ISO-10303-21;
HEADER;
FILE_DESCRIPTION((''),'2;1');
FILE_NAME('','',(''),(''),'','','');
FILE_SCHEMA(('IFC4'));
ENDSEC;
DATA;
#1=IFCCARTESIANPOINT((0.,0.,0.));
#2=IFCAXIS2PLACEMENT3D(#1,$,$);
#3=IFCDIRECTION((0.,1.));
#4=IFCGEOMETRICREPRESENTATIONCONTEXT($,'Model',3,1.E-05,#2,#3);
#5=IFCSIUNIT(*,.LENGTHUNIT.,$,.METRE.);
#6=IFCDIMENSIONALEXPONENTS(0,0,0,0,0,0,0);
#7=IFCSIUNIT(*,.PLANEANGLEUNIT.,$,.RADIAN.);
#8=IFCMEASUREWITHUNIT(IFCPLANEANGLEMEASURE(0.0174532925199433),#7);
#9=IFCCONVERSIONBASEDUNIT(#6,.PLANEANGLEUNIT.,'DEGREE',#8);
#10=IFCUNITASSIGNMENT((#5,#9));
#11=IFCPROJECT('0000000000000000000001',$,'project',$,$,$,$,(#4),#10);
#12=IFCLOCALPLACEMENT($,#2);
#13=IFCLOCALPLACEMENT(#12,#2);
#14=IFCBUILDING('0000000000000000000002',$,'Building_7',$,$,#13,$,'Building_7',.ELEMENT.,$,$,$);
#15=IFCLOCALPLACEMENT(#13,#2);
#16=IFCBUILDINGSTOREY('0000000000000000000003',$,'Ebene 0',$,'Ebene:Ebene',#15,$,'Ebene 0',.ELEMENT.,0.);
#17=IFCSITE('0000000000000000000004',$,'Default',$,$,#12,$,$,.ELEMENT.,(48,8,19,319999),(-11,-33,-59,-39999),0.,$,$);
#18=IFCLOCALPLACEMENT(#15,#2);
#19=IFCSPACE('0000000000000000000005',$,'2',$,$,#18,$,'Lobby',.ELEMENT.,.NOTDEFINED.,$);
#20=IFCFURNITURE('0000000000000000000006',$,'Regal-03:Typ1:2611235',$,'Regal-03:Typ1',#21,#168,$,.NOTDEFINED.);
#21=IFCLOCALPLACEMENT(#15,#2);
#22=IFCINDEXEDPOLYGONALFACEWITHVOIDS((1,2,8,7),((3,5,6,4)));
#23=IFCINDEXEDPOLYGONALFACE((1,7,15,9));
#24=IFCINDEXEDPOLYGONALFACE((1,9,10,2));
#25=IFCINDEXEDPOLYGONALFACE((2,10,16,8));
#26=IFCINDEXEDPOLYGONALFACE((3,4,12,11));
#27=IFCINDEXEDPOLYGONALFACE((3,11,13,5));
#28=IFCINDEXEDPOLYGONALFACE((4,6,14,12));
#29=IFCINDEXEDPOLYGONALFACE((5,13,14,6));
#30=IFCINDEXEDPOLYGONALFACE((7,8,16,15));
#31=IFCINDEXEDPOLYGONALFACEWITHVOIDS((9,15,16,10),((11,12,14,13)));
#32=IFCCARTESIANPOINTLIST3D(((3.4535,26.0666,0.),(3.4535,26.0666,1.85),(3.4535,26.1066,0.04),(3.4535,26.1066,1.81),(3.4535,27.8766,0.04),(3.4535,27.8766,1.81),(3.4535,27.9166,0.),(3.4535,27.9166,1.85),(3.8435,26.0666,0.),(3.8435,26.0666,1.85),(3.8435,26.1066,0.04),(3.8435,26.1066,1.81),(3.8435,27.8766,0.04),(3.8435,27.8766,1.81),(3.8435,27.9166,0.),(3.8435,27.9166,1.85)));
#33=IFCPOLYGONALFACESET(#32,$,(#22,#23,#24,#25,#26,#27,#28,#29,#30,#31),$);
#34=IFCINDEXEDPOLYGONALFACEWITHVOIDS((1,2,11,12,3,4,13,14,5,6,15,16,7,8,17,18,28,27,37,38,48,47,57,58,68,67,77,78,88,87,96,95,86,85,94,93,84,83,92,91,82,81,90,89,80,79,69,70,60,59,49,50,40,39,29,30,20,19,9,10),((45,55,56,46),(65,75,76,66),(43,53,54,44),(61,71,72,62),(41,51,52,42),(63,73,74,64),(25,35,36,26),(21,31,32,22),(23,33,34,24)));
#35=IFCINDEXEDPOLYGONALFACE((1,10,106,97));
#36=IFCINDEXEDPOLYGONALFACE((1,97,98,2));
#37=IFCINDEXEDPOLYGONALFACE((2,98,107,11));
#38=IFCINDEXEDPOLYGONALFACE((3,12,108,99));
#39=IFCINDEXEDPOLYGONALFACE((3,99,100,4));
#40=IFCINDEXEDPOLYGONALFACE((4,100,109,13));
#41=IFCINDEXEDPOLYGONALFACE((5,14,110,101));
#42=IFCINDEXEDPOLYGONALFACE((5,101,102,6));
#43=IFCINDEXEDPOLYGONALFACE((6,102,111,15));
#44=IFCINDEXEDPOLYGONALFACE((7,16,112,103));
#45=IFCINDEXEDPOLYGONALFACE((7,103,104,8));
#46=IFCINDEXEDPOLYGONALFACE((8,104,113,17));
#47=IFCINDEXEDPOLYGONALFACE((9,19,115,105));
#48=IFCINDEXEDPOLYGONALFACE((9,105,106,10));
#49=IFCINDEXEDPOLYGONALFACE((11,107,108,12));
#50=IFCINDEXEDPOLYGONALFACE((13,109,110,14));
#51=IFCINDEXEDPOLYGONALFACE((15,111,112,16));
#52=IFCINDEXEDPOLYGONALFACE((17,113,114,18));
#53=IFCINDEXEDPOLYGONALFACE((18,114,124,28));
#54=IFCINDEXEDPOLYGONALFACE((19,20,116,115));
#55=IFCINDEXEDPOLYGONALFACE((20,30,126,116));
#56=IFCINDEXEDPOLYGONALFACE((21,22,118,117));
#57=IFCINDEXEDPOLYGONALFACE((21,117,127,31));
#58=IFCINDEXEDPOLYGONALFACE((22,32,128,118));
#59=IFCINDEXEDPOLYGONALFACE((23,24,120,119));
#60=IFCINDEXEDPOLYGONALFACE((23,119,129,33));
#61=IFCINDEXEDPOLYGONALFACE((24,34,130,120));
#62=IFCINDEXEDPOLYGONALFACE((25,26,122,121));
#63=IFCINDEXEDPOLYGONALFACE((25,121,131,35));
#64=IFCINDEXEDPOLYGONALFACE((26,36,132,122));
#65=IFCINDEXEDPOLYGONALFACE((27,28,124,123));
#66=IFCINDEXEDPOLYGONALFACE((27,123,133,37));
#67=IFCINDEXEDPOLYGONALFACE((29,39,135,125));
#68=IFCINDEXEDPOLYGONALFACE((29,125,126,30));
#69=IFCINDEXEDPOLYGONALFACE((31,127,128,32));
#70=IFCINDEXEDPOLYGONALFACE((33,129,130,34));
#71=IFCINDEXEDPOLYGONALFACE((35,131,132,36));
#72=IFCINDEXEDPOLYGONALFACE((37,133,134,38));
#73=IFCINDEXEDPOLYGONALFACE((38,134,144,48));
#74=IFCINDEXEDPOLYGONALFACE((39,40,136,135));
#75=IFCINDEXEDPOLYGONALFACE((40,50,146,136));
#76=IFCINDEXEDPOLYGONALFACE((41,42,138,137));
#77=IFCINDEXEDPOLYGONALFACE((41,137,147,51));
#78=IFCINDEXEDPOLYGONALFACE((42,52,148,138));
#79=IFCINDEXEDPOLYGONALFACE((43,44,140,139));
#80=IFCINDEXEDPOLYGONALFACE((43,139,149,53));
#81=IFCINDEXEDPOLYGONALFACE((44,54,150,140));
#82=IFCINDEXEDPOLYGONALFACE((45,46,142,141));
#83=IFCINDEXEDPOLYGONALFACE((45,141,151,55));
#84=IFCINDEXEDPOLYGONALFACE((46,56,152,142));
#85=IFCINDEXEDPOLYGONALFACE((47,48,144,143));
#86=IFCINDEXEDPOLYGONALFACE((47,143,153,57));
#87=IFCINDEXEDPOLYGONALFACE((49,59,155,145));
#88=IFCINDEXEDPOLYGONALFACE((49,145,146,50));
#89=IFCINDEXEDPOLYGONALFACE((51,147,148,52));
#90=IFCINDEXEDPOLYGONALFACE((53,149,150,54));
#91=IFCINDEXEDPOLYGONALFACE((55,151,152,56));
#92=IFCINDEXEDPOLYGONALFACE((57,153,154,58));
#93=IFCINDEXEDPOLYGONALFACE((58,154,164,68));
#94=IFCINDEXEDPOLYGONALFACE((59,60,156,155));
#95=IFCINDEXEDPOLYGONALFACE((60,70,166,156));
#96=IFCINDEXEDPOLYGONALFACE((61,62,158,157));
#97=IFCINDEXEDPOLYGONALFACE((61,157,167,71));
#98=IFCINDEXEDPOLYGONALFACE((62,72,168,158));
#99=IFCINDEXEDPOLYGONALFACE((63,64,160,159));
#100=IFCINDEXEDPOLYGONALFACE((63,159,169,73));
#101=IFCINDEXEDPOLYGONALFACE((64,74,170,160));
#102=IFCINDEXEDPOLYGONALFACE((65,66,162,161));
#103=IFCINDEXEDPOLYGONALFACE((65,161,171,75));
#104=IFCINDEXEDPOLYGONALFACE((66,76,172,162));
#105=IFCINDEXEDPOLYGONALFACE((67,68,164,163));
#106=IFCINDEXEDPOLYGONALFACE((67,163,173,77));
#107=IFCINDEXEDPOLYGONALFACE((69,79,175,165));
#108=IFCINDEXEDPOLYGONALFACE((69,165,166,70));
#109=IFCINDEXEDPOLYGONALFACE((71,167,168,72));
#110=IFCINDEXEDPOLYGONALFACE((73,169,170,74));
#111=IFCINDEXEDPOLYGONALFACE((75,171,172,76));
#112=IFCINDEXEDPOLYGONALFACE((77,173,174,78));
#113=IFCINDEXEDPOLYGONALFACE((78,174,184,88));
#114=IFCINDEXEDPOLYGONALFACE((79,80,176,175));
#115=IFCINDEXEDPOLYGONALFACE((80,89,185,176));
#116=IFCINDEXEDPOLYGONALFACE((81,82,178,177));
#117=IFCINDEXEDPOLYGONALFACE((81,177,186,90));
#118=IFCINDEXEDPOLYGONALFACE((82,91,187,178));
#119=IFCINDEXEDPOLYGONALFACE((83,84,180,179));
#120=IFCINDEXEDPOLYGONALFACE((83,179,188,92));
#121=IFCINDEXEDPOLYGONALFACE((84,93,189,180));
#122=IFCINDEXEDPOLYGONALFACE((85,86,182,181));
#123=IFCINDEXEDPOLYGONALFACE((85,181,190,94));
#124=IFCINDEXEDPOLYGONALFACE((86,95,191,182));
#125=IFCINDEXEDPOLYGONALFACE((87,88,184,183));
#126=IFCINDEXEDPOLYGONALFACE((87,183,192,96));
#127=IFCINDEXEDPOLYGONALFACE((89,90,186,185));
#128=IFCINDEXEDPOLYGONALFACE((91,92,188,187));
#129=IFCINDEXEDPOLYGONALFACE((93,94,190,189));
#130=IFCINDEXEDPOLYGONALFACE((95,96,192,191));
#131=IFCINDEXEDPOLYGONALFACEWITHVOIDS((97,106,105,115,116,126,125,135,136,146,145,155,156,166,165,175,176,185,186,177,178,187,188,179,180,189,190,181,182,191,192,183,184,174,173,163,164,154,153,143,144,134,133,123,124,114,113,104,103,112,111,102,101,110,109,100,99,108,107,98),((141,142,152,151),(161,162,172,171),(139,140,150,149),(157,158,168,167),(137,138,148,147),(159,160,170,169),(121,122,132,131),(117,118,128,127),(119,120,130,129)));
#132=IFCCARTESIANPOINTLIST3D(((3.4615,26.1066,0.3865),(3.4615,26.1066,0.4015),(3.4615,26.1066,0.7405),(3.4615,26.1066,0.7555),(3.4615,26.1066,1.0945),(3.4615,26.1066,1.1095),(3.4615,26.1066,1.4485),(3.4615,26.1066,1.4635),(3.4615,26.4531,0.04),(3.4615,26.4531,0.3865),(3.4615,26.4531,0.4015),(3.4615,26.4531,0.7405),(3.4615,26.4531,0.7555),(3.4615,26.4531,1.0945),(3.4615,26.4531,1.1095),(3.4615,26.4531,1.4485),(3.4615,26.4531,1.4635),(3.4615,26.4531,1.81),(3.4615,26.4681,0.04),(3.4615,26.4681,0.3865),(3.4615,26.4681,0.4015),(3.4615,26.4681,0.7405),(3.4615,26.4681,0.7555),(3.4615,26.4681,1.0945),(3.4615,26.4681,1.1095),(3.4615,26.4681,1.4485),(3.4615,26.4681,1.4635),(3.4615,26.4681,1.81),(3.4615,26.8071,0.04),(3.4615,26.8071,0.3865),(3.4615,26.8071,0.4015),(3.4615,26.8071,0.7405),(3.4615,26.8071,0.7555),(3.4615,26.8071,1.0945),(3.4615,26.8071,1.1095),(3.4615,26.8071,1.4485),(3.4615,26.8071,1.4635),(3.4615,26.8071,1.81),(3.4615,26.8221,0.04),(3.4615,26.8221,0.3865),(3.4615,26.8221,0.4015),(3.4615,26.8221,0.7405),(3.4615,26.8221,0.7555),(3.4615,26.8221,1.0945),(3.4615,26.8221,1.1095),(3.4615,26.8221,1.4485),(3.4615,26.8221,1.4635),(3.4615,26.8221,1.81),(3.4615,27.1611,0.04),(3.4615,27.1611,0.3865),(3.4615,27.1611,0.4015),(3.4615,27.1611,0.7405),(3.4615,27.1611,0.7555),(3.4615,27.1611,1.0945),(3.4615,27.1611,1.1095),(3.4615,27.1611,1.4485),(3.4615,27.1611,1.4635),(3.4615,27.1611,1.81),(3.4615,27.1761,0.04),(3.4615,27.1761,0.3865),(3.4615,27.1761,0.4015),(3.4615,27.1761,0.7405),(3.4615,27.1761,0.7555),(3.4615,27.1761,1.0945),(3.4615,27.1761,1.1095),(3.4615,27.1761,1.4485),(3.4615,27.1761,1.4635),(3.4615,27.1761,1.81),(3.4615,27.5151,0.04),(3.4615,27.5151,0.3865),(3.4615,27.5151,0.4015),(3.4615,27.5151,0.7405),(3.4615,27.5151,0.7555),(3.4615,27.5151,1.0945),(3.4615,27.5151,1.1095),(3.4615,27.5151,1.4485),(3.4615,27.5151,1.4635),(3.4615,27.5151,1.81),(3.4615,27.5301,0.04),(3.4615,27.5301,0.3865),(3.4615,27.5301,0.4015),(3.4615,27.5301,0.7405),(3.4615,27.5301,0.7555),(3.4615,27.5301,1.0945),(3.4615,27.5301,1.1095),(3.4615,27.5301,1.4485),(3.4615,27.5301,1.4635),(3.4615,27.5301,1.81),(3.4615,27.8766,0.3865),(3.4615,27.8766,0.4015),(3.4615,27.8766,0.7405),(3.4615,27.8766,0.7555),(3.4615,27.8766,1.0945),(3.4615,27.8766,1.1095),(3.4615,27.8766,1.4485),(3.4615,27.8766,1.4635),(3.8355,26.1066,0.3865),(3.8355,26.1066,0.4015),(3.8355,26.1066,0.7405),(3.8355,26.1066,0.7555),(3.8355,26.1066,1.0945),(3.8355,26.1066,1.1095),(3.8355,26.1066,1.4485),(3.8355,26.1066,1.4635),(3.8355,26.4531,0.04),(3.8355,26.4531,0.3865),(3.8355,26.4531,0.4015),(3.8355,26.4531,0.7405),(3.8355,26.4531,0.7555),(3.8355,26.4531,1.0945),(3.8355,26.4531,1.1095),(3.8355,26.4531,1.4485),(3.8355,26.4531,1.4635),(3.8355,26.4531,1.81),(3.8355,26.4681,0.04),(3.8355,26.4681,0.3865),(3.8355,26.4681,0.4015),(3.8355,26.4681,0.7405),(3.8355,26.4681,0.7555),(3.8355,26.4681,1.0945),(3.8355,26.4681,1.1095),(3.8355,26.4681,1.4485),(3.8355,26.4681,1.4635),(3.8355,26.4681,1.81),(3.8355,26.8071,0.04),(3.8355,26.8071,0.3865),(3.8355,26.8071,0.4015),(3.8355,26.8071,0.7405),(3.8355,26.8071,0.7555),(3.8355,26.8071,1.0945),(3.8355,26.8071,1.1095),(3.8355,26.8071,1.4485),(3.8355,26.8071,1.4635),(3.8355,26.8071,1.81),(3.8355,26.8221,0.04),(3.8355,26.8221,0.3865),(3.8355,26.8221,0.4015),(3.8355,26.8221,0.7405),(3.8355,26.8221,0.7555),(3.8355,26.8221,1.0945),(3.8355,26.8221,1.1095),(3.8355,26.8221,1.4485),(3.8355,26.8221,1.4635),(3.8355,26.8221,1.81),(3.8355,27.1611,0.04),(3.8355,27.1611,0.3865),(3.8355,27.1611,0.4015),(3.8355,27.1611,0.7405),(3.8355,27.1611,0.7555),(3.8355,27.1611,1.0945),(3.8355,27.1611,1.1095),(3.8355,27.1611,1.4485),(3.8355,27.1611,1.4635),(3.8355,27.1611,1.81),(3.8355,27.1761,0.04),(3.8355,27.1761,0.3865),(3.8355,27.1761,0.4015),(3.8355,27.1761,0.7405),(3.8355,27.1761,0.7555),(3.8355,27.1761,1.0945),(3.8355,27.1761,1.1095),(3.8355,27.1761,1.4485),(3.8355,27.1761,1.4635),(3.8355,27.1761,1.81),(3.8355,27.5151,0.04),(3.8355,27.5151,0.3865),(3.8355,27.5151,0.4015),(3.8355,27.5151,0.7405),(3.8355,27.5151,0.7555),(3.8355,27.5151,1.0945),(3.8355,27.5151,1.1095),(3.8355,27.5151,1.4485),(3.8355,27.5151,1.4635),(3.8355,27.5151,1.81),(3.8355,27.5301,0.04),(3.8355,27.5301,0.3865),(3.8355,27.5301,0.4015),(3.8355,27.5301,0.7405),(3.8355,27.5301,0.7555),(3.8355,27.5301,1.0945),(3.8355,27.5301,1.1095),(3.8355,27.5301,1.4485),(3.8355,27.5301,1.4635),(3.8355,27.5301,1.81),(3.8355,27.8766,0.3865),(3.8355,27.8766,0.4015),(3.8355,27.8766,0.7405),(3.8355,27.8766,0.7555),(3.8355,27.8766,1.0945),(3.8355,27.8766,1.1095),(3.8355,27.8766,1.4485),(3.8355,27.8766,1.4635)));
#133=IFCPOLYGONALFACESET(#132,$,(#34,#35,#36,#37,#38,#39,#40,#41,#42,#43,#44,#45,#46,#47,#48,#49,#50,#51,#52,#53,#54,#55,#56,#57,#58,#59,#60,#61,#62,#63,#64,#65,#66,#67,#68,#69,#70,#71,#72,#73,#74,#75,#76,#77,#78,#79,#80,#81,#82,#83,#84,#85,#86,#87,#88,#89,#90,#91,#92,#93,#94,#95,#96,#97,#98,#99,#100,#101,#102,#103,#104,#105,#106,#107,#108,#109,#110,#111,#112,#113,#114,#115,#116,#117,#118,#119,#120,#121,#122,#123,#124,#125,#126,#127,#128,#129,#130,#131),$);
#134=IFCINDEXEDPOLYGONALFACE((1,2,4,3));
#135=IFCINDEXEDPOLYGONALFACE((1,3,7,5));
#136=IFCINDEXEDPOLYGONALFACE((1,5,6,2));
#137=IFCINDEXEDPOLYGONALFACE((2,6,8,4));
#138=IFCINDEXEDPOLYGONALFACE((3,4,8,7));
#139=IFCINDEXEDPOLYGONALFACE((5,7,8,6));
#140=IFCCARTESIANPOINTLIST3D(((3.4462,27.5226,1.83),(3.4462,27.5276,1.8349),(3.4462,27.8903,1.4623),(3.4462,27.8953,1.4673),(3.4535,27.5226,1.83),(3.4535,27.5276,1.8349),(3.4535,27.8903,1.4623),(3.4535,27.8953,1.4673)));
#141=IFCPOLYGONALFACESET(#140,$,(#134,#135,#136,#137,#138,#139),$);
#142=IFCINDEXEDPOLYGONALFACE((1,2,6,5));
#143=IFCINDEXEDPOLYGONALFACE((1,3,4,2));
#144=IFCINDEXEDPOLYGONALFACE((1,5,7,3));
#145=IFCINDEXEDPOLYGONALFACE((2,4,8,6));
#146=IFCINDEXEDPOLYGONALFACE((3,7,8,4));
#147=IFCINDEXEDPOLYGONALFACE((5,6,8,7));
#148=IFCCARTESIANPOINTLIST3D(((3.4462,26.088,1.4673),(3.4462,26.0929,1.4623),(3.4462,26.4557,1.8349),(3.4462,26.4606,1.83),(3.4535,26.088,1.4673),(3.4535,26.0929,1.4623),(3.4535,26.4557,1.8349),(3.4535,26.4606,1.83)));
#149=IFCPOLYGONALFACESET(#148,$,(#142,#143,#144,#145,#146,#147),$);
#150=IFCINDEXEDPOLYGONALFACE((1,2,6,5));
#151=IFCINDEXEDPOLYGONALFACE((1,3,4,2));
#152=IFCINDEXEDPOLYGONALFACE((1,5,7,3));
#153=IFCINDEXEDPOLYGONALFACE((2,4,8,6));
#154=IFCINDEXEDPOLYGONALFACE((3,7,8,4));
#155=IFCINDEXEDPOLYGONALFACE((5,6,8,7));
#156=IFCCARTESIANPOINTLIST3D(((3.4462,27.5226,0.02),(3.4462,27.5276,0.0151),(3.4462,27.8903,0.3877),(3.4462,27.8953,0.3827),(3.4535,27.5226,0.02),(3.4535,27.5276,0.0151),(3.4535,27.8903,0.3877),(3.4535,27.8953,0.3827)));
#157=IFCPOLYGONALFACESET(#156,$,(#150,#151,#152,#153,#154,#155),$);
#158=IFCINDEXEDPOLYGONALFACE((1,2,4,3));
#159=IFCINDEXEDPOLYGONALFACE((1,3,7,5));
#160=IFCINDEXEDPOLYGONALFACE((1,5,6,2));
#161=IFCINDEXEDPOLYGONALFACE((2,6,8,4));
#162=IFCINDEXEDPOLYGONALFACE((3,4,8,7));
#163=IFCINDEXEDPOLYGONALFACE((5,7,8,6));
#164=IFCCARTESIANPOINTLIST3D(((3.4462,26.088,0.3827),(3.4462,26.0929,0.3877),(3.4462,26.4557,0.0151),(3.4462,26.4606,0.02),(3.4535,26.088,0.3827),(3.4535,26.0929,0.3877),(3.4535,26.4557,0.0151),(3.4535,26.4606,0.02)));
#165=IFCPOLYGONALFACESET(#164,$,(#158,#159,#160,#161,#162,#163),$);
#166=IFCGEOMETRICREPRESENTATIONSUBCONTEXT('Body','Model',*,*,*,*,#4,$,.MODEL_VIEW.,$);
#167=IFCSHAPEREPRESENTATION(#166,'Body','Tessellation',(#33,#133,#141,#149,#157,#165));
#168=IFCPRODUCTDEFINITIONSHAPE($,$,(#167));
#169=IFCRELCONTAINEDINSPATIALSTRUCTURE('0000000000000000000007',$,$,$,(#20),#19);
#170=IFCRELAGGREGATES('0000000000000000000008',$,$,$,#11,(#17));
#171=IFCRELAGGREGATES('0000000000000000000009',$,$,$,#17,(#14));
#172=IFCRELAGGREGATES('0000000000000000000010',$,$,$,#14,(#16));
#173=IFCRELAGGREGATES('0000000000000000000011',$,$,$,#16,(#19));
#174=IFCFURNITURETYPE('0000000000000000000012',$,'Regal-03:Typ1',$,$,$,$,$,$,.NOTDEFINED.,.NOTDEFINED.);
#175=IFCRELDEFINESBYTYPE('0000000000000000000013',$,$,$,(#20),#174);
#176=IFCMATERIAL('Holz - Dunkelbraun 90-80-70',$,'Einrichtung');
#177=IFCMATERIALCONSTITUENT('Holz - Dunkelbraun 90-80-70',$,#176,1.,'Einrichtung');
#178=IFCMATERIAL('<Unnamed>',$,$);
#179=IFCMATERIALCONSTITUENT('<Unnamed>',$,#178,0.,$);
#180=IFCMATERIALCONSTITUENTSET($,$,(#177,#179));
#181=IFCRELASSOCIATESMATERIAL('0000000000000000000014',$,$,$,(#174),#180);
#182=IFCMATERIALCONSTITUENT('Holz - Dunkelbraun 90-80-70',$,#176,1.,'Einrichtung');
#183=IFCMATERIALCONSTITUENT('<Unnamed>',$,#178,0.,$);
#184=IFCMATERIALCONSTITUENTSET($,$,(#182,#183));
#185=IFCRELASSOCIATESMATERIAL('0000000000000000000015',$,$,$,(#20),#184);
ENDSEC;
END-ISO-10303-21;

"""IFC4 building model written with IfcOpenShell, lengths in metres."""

from ifc_helpers import new_model, entity, si_unit, converted_unit, direction, frame, origin, place, context, subcontext, project, spatial, indexed_curve, outline, extrude, source, transform, mapped, material, constituent, constituent_set, type_object, type_shapes, element, save


model = new_model("IFC4")

# Units and contexts
model_context = context("Model", 3, precision=1e-05, world=origin(), true_north=direction((0.0, 1.0)))
body_context = subcontext(model_context, "Body", "Model", "MODEL_VIEW")
ifc_project = project(units=[si_unit("LENGTHUNIT", "METRE"), converted_unit("PLANEANGLEUNIT", "DEGREE", entity("IfcPlaneAngleMeasure", 0.0174532925199433), si_unit("PLANEANGLEUNIT", "RADIAN"), dimensions=[0, 0, 0, 0, 0, 0, 0])], contexts=[model_context])

# Site, building, storey
site_placement = place(None, origin())
site = spatial("IfcSite", under=ifc_project, at=site_placement, Name="Default", CompositionType="ELEMENT", RefLatitude=(48, 8, 19, 319999), RefLongitude=(-11, -33, -59, -39999), RefElevation=0.0)
building_placement = place(site_placement, origin())
building = spatial("IfcBuilding", under=site, at=building_placement, Name="Building_7", LongName="Building_7", CompositionType="ELEMENT")
storey_placement = place(building_placement, origin())
storey = spatial("IfcBuildingStorey", under=building, at=storey_placement, Name="Ebene 0", ObjectType="Ebene:Ebene", LongName="Ebene 0", CompositionType="ELEMENT", Elevation=0.0)

# Shared definitions
ifc_material_1 = material(Name="<Unnamed>")

# Shared definitions
space_1_placement = place(storey_placement, origin())
space_1 = spatial("IfcSpace", under=storey, at=space_1_placement, Name="2", LongName="Lobby", CompositionType="ELEMENT", PredefinedType="NOTDEFINED")

# Shared definitions
ifc_material_2 = material(Name="Holz - Dunkelbraun 90-80-70", Category="Einrichtung")

# Furniture
ifc_constituent_1 = constituent(ifc_material_2, Name="Holz - Dunkelbraun 90-80-70", Category="Einrichtung", fraction=1.0)
ifc_constituent_2 = constituent(ifc_material_1, Name="<Unnamed>", fraction=0.0)
ifc_constituent_set_1 = constituent_set(constituents=[ifc_constituent_1, ifc_constituent_2])
furniture_type_1 = type_object("IfcFurnitureType", Name="Regal-03:Typ1", AssemblyPlace="NOTDEFINED", PredefinedType="NOTDEFINED", material=ifc_constituent_set_1)
shared_shape_1 = source(origin(), body_context, "Body", "SweptSolid", [
    extrude(outline(indexed_curve([(-0.925, -0.925), (0.925, -0.925), (0.925, 0.925), (-0.925, 0.925), (-0.925, -0.925)], self_intersect=False), holes=[indexed_curve([(-0.885, -0.885), (-0.885, 0.885), (0.885, 0.885), (0.885, -0.885), (-0.885, -0.885)], self_intersect=False)]), frame((0.2471, -0.2651, 0.925), z_axis=(0.0, 1.0, 0.0), x_axis=(0.0, 0.0, -1.0)), (0.0, 0.0, 1.0), 0.39),
    extrude(outline(indexed_curve([(0.5385, -0.5385), (0.885, -0.5385), (0.885, -0.5235), (0.5385, -0.5235), (0.5385, -0.1845), (0.885, -0.1845), (0.885, -0.1695), (0.5385, -0.1695), (0.5385, 0.1695), (0.885, 0.1695), (0.885, 0.1845), (0.5385, 0.1845), (0.5385, 0.5235), (0.885, 0.5235), (0.885, 0.5385), (0.5385, 0.5385), (0.5385, 0.885), (0.5235, 0.885), (0.5235, 0.5385), (0.1845, 0.5385), (0.1845, 0.885), (0.1695, 0.885), (0.1695, 0.5385), (-0.1695, 0.5385), (-0.1695, 0.885), (-0.1845, 0.885), (-0.1845, 0.5385), (-0.5235, 0.5385), (-0.5235, 0.885), (-0.5385, 0.885), (-0.5385, 0.5385), (-0.885, 0.5385), (-0.885, 0.5235), (-0.5385, 0.5235), (-0.5385, 0.1845), (-0.885, 0.1845), (-0.885, 0.1695), (-0.5385, 0.1695), (-0.5385, -0.1695), (-0.885, -0.1695), (-0.885, -0.1845), (-0.5385, -0.1845), (-0.5385, -0.5235), (-0.885, -0.5235), (-0.885, -0.5385), (-0.5385, -0.5385), (-0.5385, -0.885), (-0.5235, -0.885), (-0.5235, -0.5385), (-0.1845, -0.5385), (-0.1845, -0.885), (-0.1695, -0.885), (-0.1695, -0.5385), (0.1695, -0.5385), (0.1695, -0.885), (0.1845, -0.885), (0.1845, -0.5385), (0.5235, -0.5385), (0.5235, -0.885), (0.5385, -0.885), (0.5385, -0.5385)], self_intersect=False), holes=[indexed_curve([(0.5235, -0.1845), (0.5235, -0.5235), (0.1845, -0.5235), (0.1845, -0.1845), (0.5235, -0.1845)], self_intersect=False), indexed_curve([(0.1845, -0.1695), (0.1845, 0.1695), (0.5235, 0.1695), (0.5235, -0.1695), (0.1845, -0.1695)], self_intersect=False), indexed_curve([(0.1845, 0.1845), (0.1845, 0.5235), (0.5235, 0.5235), (0.5235, 0.1845), (0.1845, 0.1845)], self_intersect=False), indexed_curve([(-0.1695, 0.5235), (0.1695, 0.5235), (0.1695, 0.1845), (-0.1695, 0.1845), (-0.1695, 0.5235)], self_intersect=False), indexed_curve([(-0.1695, 0.1695), (0.1695, 0.1695), (0.1695, -0.1695), (-0.1695, -0.1695), (-0.1695, 0.1695)], self_intersect=False), indexed_curve([(-0.1695, -0.1845), (0.1695, -0.1845), (0.1695, -0.5235), (-0.1695, -0.5235), (-0.1695, -0.1845)], self_intersect=False), indexed_curve([(-0.5235, -0.5235), (-0.5235, -0.1845), (-0.1845, -0.1845), (-0.1845, -0.5235), (-0.5235, -0.5235)], self_intersect=False), indexed_curve([(-0.5235, -0.1695), (-0.5235, 0.1695), (-0.1845, 0.1695), (-0.1845, -0.1695), (-0.5235, -0.1695)], self_intersect=False), indexed_curve([(-0.5235, 0.1845), (-0.5235, 0.5235), (-0.1845, 0.5235), (-0.1845, 0.1845), (-0.5235, 0.1845)], self_intersect=False)]), frame((0.2471, -0.2571, 0.925), z_axis=(0.0, 1.0, 0.0), x_axis=(0.0, 0.0, 1.0)), (0.0, 0.0, 1.0), 0.374),
    extrude(outline(indexed_curve([(-0.0037, -0.0035), (0.0037, -0.0035), (0.0037, 0.0035), (-0.0037, 0.0035), (-0.0037, -0.0035)], self_intersect=False)), frame((1.1482, 0.1286, 1.4648), z_axis=(-0.707107, 0.0, 0.707107), x_axis=(0.0, 1.0, 0.0)), (0.0, 0.0, 1.0), 0.52),
    extrude(outline(indexed_curve([(-0.0037, -0.0035), (0.0037, -0.0035), (0.0037, 0.0035), (-0.0037, 0.0035), (-0.0037, -0.0035)], self_intersect=False)), frame((-0.6541, 0.1286, 1.4648), z_axis=(0.707107, 0.0, 0.707107), x_axis=(0.0, 1.0, 0.0)), (0.0, 0.0, 1.0), 0.52),
    extrude(outline(indexed_curve([(-0.0037, -0.0035), (0.0037, -0.0035), (0.0037, 0.0035), (-0.0037, 0.0035), (-0.0037, -0.0035)], self_intersect=False)), frame((0.7805, 0.1286, 0.0175), z_axis=(0.707107, 0.0, 0.707107), x_axis=(0.0, 1.0, 0.0)), (0.0, 0.0, 1.0), 0.52),
    extrude(outline(indexed_curve([(-0.0037, -0.0035), (0.0037, -0.0035), (0.0037, 0.0035), (-0.0037, 0.0035), (-0.0037, -0.0035)], self_intersect=False)), frame((-0.2864, 0.1286, 0.0175), z_axis=(-0.707107, 0.0, 0.707107), x_axis=(0.0, 1.0, 0.0)), (0.0, 0.0, 1.0), 0.52),
])
type_shapes(furniture_type_1, [shared_shape_1])
ifc_constituent_3 = constituent(ifc_material_2, Name="Holz - Dunkelbraun 90-80-70", Category="Einrichtung", fraction=1.0)
ifc_constituent_4 = constituent(ifc_material_1, Name="<Unnamed>", fraction=0.0)
ifc_constituent_set_2 = constituent_set(constituents=[ifc_constituent_3, ifc_constituent_4])
furniture_1_placement = place(space_1_placement, frame((3.5784, 26.7446, 0.0), z_axis=(0.0, 0.0, 1.0), x_axis=(0.0, 1.0, 0.0)))
element("IfcFurniture", 1, at=furniture_1_placement, inside=space_1, type_object=furniture_type_1, material=ifc_constituent_set_2, Name="Regal-03:Typ1:2611235", ObjectType="Regal-03:Typ1", PredefinedType="NOTDEFINED", context=body_context, shape_type="MappedRepresentation", body=[
    mapped(shared_shape_1, transform((0.0, 0.0, 0.0), scale=1.0)),
])

save(model, "model.ifc")
